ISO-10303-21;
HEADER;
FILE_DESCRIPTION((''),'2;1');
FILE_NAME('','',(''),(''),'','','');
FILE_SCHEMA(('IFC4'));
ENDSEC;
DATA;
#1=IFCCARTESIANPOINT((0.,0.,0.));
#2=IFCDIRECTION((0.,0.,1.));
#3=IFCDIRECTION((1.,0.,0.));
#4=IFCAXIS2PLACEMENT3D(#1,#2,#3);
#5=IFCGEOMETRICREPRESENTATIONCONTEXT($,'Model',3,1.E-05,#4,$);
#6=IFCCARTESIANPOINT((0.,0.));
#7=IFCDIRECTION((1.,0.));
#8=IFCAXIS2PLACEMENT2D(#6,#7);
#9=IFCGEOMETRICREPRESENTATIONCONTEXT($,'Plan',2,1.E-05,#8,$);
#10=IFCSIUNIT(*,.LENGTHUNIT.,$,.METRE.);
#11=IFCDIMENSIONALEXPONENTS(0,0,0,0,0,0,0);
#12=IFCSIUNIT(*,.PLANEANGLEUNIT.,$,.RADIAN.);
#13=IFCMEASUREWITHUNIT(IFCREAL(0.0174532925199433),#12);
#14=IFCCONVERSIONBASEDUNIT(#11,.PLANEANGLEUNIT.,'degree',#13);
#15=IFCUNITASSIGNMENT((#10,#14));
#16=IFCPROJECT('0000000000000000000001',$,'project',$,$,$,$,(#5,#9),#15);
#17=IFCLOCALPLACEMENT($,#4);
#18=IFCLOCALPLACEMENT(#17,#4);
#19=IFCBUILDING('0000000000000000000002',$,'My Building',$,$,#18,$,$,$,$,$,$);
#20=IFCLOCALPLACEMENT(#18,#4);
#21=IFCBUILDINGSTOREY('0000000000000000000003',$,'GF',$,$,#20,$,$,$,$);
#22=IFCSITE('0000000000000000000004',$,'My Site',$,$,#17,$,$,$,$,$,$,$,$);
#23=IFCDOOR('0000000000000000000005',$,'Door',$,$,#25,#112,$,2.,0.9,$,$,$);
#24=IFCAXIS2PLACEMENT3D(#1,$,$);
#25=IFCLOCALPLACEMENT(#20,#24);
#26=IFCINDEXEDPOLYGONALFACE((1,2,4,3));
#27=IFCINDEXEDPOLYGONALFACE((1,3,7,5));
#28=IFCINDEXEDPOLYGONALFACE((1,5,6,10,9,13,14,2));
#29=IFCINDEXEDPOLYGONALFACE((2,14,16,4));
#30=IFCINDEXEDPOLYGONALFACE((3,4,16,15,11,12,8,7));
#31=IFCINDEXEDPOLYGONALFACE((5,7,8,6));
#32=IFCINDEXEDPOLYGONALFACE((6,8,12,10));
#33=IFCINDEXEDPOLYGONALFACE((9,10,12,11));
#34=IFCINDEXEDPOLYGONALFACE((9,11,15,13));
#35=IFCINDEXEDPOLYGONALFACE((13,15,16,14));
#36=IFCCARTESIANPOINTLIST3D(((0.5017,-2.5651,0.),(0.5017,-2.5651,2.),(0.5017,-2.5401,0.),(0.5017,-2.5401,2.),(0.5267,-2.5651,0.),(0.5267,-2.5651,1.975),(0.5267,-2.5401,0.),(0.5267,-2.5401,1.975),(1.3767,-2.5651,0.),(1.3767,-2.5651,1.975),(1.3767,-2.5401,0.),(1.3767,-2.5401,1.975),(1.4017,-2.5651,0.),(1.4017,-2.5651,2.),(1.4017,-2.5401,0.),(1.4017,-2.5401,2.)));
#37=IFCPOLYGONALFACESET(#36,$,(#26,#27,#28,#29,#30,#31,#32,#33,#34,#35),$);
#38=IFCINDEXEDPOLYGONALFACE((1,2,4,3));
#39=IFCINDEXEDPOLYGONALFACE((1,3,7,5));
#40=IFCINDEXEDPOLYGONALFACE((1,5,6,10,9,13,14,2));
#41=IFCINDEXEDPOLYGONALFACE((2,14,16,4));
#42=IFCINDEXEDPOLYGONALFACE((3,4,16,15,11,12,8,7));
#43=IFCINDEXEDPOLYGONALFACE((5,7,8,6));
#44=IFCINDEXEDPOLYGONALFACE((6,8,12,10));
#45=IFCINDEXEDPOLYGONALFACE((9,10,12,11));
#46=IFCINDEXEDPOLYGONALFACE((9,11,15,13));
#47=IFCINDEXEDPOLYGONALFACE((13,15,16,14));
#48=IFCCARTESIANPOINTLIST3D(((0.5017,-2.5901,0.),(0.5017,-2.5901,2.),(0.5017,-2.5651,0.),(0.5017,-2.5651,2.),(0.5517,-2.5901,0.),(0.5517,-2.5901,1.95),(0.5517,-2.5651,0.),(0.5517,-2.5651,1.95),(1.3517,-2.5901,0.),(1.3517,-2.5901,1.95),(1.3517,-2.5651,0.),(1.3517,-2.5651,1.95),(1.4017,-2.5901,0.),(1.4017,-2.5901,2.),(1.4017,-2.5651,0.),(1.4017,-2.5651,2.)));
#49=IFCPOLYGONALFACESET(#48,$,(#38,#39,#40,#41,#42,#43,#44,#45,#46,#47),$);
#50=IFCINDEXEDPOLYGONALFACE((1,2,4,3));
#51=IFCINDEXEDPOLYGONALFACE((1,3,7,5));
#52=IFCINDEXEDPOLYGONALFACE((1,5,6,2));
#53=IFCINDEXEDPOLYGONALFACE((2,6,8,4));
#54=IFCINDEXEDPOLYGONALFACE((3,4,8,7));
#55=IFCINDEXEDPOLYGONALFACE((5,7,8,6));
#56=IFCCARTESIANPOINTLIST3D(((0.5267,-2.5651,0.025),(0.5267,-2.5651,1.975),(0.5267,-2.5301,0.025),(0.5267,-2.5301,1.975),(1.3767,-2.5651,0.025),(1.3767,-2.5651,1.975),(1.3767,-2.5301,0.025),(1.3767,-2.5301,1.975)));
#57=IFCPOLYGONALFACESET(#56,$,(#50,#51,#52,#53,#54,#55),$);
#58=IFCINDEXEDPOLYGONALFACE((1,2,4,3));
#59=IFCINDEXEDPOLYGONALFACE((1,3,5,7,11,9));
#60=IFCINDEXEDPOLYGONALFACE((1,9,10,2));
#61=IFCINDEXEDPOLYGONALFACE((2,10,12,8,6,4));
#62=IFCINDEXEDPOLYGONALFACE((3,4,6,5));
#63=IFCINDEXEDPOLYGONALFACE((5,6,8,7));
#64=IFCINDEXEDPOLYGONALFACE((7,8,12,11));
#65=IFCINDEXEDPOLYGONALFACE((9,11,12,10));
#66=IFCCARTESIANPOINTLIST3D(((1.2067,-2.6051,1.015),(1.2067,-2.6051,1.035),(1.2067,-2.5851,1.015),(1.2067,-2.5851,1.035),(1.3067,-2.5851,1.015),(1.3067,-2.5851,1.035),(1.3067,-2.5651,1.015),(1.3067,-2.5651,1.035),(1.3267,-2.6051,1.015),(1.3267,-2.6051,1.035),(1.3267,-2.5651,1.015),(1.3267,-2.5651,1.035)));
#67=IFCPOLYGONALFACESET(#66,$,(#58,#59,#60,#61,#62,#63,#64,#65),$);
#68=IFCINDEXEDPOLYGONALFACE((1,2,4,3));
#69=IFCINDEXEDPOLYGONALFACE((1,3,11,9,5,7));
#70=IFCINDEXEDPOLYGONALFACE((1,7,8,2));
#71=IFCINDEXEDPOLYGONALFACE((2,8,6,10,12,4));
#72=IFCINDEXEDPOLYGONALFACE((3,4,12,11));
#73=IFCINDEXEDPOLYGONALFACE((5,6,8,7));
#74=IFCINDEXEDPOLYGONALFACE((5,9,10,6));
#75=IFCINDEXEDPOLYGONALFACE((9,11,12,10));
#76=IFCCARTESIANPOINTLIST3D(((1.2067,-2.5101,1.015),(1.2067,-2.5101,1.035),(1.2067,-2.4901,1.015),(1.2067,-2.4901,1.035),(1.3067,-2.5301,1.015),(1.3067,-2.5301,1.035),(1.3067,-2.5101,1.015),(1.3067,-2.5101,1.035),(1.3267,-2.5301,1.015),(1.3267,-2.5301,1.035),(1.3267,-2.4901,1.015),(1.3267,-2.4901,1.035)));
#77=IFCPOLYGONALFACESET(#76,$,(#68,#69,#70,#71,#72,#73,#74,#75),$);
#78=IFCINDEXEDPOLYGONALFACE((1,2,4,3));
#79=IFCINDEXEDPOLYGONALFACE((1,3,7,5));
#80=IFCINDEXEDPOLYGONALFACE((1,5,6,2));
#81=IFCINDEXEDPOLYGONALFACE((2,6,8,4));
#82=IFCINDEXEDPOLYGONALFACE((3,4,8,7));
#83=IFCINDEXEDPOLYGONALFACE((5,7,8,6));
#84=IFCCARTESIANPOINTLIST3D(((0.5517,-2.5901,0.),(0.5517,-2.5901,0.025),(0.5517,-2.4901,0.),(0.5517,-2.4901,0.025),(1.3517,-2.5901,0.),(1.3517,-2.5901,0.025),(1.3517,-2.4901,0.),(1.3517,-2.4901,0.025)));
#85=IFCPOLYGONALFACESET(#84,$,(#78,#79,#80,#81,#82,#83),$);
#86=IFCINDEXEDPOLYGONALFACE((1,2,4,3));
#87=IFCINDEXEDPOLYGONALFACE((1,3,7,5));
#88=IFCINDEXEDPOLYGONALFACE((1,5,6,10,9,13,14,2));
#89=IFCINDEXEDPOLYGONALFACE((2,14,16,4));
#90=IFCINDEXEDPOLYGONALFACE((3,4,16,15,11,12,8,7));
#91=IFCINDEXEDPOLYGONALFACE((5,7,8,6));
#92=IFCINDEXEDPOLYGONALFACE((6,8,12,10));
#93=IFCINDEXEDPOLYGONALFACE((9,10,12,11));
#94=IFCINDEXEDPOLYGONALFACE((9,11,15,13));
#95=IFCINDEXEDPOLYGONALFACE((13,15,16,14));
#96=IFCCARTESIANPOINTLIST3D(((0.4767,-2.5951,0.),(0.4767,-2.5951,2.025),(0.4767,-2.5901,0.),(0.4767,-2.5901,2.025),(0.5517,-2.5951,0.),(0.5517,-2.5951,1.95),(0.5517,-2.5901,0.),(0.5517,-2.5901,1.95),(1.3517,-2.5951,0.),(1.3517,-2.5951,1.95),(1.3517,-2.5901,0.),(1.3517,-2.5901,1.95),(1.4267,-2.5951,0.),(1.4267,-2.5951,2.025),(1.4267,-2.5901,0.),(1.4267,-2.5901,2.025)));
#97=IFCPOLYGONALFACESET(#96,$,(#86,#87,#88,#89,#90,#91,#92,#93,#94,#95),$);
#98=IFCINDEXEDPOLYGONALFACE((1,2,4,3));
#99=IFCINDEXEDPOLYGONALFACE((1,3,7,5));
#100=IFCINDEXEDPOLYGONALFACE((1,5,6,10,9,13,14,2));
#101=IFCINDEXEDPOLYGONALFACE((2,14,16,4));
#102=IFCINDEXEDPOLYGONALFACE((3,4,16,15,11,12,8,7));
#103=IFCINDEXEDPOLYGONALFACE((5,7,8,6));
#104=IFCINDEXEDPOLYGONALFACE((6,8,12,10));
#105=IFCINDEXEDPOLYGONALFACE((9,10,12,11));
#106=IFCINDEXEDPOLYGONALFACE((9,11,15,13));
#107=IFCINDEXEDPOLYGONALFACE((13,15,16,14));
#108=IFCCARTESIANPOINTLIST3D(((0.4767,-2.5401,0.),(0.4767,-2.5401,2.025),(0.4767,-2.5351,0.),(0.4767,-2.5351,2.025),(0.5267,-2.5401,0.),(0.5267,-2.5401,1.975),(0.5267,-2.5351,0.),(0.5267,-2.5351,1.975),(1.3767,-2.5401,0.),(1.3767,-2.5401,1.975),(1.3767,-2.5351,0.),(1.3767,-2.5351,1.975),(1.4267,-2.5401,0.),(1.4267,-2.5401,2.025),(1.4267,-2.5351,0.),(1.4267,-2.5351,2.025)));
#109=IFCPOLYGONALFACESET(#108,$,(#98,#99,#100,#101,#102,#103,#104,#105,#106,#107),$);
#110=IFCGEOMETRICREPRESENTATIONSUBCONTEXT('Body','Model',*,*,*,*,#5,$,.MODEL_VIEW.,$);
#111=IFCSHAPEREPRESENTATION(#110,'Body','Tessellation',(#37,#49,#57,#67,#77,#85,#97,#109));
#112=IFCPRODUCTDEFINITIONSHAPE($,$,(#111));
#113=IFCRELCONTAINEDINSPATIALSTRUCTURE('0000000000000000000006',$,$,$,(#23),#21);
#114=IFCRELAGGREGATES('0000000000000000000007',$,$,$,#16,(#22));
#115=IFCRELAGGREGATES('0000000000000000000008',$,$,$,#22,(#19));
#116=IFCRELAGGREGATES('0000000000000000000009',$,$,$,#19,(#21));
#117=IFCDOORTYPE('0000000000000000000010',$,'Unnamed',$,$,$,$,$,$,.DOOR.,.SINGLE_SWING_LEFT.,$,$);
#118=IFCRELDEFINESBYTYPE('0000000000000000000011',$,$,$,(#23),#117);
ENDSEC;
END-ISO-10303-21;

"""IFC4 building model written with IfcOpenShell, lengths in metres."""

from ifc_helpers import new_model, entity, si_unit, converted_unit, frame, origin_with_axes, origin_2d_with_axis, place, context, subcontext, project, spatial, line, indexed_curve, outline, extrude, shape, source, transform, mapped, type_object, type_shapes, element, save


model = new_model("IFC4")

# Units and contexts
model_context = context("Model", 3, precision=1e-05, world=origin_with_axes())
plan_context = context("Plan", 2, precision=1e-05, world=origin_2d_with_axis())
body_context_1 = subcontext(model_context, "Body", "Model", "MODEL_VIEW")
body_context_2 = subcontext(plan_context, "Body", "Plan", "PLAN_VIEW")
ifc_project = project(units=[si_unit("LENGTHUNIT", "METRE"), converted_unit("PLANEANGLEUNIT", "degree", entity("IfcReal", 0.0174532925199433), si_unit("PLANEANGLEUNIT", "RADIAN"), dimensions=[0, 0, 0, 0, 0, 0, 0])], contexts=[model_context, plan_context])

# Site, building, storey
site_placement = place(None, origin_with_axes())
site = spatial("IfcSite", under=ifc_project, at=site_placement, Name="My Site")
building_placement = place(site_placement, origin_with_axes())
building = spatial("IfcBuilding", under=site, at=building_placement, Name="My Building")
storey_placement = place(building_placement, origin_with_axes())
storey = spatial("IfcBuildingStorey", under=building, at=storey_placement, Name="GF")

# Shared definitions
door_type = type_object("IfcDoorType", Name="Unnamed", OperationType="SINGLE_SWING_LEFT", PredefinedType="DOOR")
shared_shape_1 = source(origin_with_axes(), body_context_1, "Body", "SweptSolid", [
    extrude(outline(indexed_curve([(0.0, 0.0), (0.0, 2.0), (0.9, 2.0), (0.9, 0.0), (0.875, 0.0), (0.875, 1.975), (0.025, 1.975), (0.025, 0.0)], segments=[line(1, 2, 3, 4, 5, 6, 7, 8, 1)])), frame((0.0, 0.025, 0.0), z_axis=(0.0, -1.0, 0.0), x_axis=(1.0, 0.0, 0.0)), (0.0, 0.0, -1.0), 0.025),
    extrude(outline(indexed_curve([(0.0, 0.0), (0.0, 2.0), (0.9, 2.0), (0.9, 0.0), (0.85, 0.0), (0.85, 1.95), (0.05, 1.95), (0.05, 0.0)], segments=[line(1, 2, 3, 4, 5, 6, 7, 8, 1)])), frame((0.0, 0.0, 0.0), z_axis=(0.0, -1.0, 0.0), x_axis=(1.0, 0.0, 0.0)), (0.0, 0.0, -1.0), 0.025),
    extrude(outline(indexed_curve([(0.0, 0.0), (0.85, 0.0), (0.85, 0.035), (0.0, 0.035)], segments=[line(1, 2, 3, 4, 1)])), frame((0.025, 0.025, 0.025), z_axis=(0.0, 0.0, 1.0), x_axis=(1.0, 0.0, 0.0)), (0.0, 0.0, 1.0), 1.95),
    extrude(outline(indexed_curve([(0.0, 0.0), (0.0, -0.04), (-0.12, -0.04), (-0.12, -0.02), (-0.02, -0.02), (-0.02, 0.0)], segments=[line(1, 2, 3, 4, 5, 6, 1)])), frame((0.825, 0.025, 1.015), z_axis=(0.0, 0.0, 1.0), x_axis=(1.0, 0.0, 0.0)), (0.0, 0.0, 1.0), 0.02),
    extrude(outline(indexed_curve([(0.0, 0.0), (0.0, 0.04), (-0.12, 0.04), (-0.12, 0.02), (-0.02, 0.02), (-0.02, 0.0)], segments=[line(1, 2, 3, 4, 5, 6, 1)])), frame((0.825, 0.06, 1.015), z_axis=(0.0, 0.0, 1.0), x_axis=(1.0, 0.0, 0.0)), (0.0, 0.0, 1.0), 0.02),
    extrude(outline(indexed_curve([(0.0, 0.0), (0.8, 0.0), (0.8, 0.1), (0.0, 0.1)], segments=[line(1, 2, 3, 4, 1)])), frame((0.05, 0.0, 0.0), z_axis=(0.0, 0.0, 1.0), x_axis=(1.0, 0.0, 0.0)), (0.0, 0.0, 1.0), 0.025),
    extrude(outline(indexed_curve([(0.0, 0.0), (0.0, 2.025), (0.95, 2.025), (0.95, 0.0), (0.875, 0.0), (0.875, 1.95), (0.075, 1.95), (0.075, 0.0)], segments=[line(1, 2, 3, 4, 5, 6, 7, 8, 1)])), frame((-0.025, -0.005, 0.0), z_axis=(0.0, -1.0, 0.0), x_axis=(1.0, 0.0, 0.0)), (0.0, 0.0, -1.0), 0.005),
    extrude(outline(indexed_curve([(0.0, 0.0), (0.0, 2.025), (0.95, 2.025), (0.95, 0.0), (0.9, 0.0), (0.9, 1.975), (0.05, 1.975), (0.05, 0.0)], segments=[line(1, 2, 3, 4, 5, 6, 7, 8, 1)])), frame((-0.025, 0.05, 0.0), z_axis=(0.0, -1.0, 0.0), x_axis=(1.0, 0.0, 0.0)), (0.0, 0.0, -1.0), 0.005),
])
shared_shape_2 = source(origin_with_axes(), body_context_2, "Body", "Curve2D", [
    entity("IfcIndexedPolyCurve", entity("IfcCartesianPointList2D", [[0.0, 0.0], [0.0, 0.05], [0.025, 0.05], [0.025, 0.025], [0.05, 0.025], [0.05, 0.0]]), [entity("IfcLineIndex", [1, 2, 3, 4, 5, 6, 1])]),
    entity("IfcIndexedPolyCurve", entity("IfcCartesianPointList2D", [[0.9, 0.0], [0.9, 0.05], [0.875, 0.05], [0.875, 0.025], [0.85, 0.025], [0.85, 0.0]]), [entity("IfcLineIndex", [1, 2, 3, 4, 5, 6, 1])]),
    entity("IfcTrimmedCurve", entity("IfcEllipse", entity("IfcAxis2Placement2D", entity("IfcCartesianPoint", [0.06, 0.05]), entity("IfcDirection", [1.0, 0.0])), 0.815, 0.85), [entity("IfcCartesianPoint", [0.875, 0.05])], [entity("IfcCartesianPoint", [0.06, 0.9])], True, "CARTESIAN"),
    entity("IfcIndexedPolyCurve", entity("IfcCartesianPointList2D", [[0.025, 0.05], [0.06, 0.05], [0.06, 0.9], [0.025, 0.9]]), [entity("IfcLineIndex", [1, 2, 3, 4, 1])]),
])
type_shapes(door_type, [shared_shape_1, shared_shape_2])

# Door
door_1_placement = place(storey_placement, frame((0.5017, -2.5901, 0.0), z_axis=(0.0, 0.0, 1.0), x_axis=(1.0, 0.0, 0.0)))
element("IfcDoor", 1, at=door_1_placement, inside=storey, type_object=door_type, Name="Door", OverallHeight=2.0, OverallWidth=0.9, shapes=[
    shape(body_context_1, "Body", "MappedRepresentation", [mapped(shared_shape_1, transform((0.0, 0.0, 0.0), x_axis=(1.0, 0.0, 0.0), y_axis=(0.0, 1.0, 0.0), z_axis=(0.0, 0.0, 1.0), scale=1.0))]),
    shape(body_context_2, "Body", "MappedRepresentation", [mapped(shared_shape_2, transform((0.0, 0.0, 0.0), x_axis=(1.0, 0.0, 0.0), y_axis=(0.0, 1.0, 0.0), z_axis=(0.0, 0.0, 1.0), scale=1.0))]),
])

save(model, "model.ifc")
